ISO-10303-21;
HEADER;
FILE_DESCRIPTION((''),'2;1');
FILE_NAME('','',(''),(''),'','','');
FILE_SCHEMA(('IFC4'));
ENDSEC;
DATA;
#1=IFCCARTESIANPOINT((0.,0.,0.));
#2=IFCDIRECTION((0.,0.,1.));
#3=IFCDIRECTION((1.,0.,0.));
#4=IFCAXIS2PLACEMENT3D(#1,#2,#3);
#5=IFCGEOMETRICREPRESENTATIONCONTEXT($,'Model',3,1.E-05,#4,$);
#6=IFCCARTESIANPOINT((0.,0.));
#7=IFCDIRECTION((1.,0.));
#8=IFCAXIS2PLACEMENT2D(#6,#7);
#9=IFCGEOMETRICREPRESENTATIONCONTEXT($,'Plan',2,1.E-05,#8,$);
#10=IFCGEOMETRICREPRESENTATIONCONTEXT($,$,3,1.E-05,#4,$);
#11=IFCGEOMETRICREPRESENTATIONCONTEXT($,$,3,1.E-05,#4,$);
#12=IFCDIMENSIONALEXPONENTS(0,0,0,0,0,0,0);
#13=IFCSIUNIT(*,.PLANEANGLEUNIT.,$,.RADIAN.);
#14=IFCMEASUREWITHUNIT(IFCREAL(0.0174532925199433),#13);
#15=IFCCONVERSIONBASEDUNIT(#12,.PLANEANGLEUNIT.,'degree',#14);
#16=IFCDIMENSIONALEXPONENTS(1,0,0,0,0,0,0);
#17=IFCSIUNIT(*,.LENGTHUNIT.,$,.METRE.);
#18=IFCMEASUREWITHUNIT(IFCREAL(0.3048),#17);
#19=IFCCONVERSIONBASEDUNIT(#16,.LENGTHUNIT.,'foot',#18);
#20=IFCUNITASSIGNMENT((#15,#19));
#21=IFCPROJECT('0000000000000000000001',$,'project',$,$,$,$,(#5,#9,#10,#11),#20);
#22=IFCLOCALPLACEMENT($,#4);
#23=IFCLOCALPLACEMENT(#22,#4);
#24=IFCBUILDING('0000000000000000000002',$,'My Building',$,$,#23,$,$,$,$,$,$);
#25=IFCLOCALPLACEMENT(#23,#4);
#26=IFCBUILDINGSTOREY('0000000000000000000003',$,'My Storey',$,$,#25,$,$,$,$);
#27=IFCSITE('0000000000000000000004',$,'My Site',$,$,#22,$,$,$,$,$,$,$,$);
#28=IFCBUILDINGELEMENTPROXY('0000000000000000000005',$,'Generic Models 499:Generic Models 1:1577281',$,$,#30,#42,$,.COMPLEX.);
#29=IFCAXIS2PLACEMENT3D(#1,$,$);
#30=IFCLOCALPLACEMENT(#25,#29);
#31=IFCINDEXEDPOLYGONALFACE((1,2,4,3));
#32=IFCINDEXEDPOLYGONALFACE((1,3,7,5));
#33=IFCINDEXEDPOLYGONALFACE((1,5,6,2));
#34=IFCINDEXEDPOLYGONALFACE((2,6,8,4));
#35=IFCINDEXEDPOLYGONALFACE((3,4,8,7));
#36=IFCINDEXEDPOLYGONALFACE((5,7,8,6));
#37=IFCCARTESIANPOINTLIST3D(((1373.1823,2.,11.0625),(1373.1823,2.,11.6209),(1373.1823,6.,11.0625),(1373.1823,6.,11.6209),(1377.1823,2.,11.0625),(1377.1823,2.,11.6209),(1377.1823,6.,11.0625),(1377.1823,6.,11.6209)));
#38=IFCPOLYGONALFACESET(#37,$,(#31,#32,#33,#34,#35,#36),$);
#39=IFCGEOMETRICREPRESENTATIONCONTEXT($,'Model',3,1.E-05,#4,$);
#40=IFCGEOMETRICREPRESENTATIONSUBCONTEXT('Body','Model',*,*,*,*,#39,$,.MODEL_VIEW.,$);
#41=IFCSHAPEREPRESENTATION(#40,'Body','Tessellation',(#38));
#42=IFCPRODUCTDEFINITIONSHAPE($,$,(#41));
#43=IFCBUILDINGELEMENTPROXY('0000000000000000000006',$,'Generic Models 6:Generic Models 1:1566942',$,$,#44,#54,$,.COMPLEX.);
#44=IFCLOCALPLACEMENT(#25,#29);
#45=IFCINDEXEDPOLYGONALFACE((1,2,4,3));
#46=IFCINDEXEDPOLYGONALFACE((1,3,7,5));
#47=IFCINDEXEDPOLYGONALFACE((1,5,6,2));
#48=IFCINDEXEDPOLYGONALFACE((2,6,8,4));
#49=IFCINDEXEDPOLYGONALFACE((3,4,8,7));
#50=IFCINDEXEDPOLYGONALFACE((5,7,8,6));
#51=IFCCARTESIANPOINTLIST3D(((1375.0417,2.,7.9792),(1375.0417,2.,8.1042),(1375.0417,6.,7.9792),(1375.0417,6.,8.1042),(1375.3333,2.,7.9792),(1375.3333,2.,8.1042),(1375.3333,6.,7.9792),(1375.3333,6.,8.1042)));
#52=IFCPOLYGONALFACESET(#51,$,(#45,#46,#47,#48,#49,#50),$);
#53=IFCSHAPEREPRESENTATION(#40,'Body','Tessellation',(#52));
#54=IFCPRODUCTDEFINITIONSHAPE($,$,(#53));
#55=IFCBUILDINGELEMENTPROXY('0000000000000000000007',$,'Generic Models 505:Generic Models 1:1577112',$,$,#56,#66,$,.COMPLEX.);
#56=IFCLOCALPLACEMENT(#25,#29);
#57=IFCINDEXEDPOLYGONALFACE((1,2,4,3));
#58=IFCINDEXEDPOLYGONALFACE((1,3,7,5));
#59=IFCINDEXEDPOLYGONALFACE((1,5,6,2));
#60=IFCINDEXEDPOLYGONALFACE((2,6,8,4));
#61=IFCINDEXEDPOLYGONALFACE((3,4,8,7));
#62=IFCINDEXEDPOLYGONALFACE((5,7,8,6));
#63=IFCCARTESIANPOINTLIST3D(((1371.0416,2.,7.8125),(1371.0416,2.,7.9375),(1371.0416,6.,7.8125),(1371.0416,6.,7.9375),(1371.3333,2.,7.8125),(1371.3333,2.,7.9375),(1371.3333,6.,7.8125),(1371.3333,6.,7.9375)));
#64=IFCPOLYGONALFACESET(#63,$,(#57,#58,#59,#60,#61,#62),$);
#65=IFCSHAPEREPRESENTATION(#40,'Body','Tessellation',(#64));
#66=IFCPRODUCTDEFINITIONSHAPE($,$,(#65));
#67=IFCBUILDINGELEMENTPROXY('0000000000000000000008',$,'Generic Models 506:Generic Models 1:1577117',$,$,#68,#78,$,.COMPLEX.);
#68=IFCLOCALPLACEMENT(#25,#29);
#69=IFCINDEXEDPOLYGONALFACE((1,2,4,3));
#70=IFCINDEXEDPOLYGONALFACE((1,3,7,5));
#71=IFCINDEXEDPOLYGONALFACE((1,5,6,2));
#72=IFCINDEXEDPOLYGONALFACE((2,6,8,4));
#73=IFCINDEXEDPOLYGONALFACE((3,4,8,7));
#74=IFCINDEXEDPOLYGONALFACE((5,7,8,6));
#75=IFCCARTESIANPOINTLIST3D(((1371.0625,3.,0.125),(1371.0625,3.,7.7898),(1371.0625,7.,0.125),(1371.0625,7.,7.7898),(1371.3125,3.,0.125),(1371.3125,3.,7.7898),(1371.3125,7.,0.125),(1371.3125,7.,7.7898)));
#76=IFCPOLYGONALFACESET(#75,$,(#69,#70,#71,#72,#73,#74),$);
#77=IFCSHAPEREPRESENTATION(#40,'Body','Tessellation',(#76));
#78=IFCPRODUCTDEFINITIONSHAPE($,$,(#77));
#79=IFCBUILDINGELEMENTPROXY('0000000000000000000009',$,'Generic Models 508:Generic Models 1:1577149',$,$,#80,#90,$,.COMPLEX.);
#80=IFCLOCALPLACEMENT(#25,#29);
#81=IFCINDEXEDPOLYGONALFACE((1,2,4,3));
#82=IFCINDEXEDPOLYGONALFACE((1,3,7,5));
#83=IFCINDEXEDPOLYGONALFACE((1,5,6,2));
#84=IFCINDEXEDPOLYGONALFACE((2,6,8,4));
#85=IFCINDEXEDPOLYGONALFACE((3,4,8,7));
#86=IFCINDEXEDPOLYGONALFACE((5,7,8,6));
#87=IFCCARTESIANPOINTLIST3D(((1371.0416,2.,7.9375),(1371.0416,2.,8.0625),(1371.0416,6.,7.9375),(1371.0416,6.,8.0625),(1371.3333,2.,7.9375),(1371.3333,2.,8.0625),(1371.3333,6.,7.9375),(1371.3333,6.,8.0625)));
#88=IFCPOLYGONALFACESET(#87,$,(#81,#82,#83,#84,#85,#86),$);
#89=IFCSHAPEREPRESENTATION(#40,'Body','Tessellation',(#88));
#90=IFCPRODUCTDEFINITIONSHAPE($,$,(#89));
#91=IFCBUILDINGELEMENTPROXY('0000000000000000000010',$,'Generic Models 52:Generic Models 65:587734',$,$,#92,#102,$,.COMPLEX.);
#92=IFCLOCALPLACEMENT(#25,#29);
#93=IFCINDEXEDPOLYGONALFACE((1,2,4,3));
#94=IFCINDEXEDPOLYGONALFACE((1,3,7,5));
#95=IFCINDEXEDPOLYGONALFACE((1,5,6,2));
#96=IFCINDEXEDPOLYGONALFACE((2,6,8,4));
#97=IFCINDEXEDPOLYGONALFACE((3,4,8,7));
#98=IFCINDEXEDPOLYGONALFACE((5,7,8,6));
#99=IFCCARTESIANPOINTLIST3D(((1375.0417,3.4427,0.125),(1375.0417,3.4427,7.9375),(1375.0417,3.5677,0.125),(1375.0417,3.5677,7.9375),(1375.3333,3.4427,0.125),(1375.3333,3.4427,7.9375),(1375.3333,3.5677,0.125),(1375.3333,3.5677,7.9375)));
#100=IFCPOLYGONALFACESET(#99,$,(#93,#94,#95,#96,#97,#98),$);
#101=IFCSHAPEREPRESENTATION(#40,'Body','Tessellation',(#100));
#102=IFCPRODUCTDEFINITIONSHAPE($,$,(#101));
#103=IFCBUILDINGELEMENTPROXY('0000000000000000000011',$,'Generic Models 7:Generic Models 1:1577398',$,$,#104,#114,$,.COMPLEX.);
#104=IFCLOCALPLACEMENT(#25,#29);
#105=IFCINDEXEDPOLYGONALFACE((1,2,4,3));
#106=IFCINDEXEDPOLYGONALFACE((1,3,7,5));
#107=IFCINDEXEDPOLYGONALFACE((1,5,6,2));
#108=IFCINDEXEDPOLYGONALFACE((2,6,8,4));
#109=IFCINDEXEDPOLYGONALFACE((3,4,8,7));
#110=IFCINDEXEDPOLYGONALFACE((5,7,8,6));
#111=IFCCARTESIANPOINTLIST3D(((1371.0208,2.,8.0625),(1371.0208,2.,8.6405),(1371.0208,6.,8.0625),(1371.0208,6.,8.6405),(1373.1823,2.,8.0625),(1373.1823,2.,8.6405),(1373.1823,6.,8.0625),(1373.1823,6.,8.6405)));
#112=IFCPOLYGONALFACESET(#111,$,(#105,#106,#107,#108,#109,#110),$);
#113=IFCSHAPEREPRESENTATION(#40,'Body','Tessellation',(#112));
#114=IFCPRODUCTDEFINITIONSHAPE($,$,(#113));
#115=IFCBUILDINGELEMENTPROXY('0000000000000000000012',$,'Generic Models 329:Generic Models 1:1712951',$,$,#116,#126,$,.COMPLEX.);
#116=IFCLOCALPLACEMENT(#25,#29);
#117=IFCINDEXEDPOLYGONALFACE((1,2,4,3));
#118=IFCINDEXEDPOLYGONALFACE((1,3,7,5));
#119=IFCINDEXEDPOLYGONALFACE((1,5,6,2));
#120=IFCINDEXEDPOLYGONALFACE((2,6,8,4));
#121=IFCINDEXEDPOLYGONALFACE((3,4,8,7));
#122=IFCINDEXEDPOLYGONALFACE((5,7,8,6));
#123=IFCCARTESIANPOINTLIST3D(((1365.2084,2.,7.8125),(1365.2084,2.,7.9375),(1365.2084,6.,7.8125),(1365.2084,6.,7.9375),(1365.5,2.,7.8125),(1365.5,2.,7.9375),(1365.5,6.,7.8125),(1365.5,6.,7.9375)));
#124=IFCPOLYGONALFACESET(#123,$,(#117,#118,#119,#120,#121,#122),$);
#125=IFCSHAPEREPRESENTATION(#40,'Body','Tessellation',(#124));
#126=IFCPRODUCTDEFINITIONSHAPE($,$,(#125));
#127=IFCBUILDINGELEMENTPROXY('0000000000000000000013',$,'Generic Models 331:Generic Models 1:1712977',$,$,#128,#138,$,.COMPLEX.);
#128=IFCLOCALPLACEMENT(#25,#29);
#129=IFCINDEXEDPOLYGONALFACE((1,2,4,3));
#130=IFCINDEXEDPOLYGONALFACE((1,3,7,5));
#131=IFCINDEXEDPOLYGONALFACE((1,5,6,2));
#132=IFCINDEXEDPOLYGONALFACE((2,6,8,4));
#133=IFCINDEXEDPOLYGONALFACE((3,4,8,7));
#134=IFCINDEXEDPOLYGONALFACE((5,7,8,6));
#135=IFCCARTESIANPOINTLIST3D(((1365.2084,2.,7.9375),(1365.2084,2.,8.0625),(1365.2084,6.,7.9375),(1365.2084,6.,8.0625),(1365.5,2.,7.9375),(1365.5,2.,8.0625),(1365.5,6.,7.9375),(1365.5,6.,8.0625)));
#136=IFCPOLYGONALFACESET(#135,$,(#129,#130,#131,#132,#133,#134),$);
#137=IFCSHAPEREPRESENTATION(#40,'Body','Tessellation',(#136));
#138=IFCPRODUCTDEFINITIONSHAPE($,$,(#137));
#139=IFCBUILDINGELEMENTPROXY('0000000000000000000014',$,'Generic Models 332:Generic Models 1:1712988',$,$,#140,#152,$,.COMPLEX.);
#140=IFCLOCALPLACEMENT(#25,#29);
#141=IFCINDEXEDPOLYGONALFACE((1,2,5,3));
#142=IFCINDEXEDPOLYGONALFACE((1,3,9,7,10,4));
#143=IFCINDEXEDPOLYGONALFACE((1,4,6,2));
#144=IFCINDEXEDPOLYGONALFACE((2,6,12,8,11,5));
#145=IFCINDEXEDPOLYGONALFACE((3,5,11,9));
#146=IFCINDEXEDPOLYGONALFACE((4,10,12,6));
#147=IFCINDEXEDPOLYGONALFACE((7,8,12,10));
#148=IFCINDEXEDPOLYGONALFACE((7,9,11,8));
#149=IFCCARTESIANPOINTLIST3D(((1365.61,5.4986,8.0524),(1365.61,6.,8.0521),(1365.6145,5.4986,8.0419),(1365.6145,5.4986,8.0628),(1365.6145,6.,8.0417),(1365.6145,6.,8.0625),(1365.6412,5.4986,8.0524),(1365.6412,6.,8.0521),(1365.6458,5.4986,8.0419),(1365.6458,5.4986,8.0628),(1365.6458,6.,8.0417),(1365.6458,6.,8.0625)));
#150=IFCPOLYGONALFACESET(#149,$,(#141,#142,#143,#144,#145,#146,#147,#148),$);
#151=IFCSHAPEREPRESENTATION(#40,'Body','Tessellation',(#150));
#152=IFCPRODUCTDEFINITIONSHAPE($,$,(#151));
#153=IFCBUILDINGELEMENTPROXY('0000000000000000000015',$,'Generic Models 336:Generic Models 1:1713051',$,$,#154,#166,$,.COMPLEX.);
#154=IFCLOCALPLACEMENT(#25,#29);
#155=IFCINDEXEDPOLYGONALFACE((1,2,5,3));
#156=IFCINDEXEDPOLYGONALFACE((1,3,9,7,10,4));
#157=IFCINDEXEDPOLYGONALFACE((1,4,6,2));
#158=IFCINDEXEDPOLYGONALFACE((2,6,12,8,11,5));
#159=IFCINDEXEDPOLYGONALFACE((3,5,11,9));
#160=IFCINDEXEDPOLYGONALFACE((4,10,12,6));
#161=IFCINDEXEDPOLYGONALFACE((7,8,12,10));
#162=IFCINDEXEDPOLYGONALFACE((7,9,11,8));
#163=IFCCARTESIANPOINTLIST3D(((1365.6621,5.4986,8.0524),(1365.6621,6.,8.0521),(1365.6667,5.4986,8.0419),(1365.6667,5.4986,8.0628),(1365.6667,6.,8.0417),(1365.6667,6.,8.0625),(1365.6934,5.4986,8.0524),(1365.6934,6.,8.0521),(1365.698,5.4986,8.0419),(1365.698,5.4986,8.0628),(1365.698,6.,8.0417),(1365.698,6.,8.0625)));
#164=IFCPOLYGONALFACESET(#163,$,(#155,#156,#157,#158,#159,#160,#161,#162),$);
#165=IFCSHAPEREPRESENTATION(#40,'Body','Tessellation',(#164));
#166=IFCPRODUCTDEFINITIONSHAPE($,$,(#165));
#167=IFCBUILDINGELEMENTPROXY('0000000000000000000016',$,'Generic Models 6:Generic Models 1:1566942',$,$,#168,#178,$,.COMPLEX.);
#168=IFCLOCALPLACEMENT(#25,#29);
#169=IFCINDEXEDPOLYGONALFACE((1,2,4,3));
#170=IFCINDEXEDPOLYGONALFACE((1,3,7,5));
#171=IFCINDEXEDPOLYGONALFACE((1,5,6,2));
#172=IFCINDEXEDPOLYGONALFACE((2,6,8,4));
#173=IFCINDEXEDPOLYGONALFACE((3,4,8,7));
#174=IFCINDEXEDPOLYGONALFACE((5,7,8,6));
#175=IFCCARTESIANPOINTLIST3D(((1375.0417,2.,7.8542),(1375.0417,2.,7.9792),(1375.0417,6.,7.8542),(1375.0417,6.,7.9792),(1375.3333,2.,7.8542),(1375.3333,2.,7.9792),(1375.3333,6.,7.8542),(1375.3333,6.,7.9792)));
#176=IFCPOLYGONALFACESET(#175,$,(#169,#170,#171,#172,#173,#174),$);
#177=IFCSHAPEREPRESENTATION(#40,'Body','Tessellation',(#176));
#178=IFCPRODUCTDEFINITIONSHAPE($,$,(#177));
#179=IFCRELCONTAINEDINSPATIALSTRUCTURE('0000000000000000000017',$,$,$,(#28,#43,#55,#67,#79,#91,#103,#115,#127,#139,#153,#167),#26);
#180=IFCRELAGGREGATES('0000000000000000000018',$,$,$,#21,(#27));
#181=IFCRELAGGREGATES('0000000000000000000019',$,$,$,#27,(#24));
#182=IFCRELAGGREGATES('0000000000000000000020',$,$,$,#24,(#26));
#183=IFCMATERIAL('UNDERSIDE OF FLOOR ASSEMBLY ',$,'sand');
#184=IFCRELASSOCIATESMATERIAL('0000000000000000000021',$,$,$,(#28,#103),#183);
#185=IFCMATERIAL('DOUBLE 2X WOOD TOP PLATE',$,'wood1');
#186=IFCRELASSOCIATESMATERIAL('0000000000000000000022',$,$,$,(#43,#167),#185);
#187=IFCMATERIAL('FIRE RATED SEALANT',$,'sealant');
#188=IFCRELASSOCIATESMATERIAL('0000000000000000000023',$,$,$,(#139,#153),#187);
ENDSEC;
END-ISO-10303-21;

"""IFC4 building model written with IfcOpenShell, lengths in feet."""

from ifc_helpers import new_model, entity, si_unit, converted_unit, frame, origin_with_axes, origin_2d_with_axis, place, context, subcontext, project, spatial, polyline, line, indexed_curve, outline, extrude, material, element, save


model = new_model("IFC4")

# Units and contexts
model_context_1 = context("Model", 3, precision=1e-05, world=origin_with_axes())
plan_context = context("Plan", 2, precision=1e-05, world=origin_2d_with_axis())
model_context_2 = context("Model", 3, precision=1e-05, world=origin_with_axes())
context_of_model_1 = context(None, 3, precision=1e-05, world=origin_with_axes())
context_of_model_2 = context(None, 3, precision=1e-05, world=origin_with_axes())
body_context = subcontext(model_context_2, "Body", "Model", "MODEL_VIEW")
ifc_project = project(units=[converted_unit("PLANEANGLEUNIT", "degree", entity("IfcReal", 0.0174532925199433), si_unit("PLANEANGLEUNIT", "RADIAN"), dimensions=[0, 0, 0, 0, 0, 0, 0]), converted_unit("LENGTHUNIT", "foot", entity("IfcReal", 0.3048), si_unit("LENGTHUNIT", "METRE"), dimensions=[1, 0, 0, 0, 0, 0, 0])], contexts=[model_context_1, plan_context, context_of_model_1, context_of_model_2])

# Site, building, storey
site_placement = place(None, origin_with_axes())
site = spatial("IfcSite", under=ifc_project, at=site_placement, Name="My Site")
building_placement = place(site_placement, origin_with_axes())
building = spatial("IfcBuilding", under=site, at=building_placement, Name="My Building")
storey_placement = place(building_placement, origin_with_axes())
storey = spatial("IfcBuildingStorey", under=building, at=storey_placement, Name="My Storey")

# Building element proxies
ifc_material_1 = material(Name="UNDERSIDE OF FLOOR ASSEMBLY ", Category="sand")
proxy_1_placement = place(storey_placement, frame((1373.1823, 6.0, 11.0625), z_axis=(0.0, -1.0, 0.0), x_axis=(0.0, 0.0, -1.0)))
element("IfcBuildingElementProxy", 1, at=proxy_1_placement, inside=storey, material=ifc_material_1, Name="Generic Models 499:Generic Models 1:1577281", PredefinedType="COMPLEX", context=body_context, shape_type="SweptSolid", body=[
    extrude(outline(indexed_curve([(-0.2792, -2.0), (0.2792, -2.0), (0.2792, 2.0), (-0.2792, 2.0)], segments=[line(3, 2), line(2, 1), line(1, 4), line(4, 3)], self_intersect=False)), frame((-0.2792, 2.0, 0.0), z_axis=(0.0, 0.0, -1.0), x_axis=(1.0, 0.0, 0.0)), (0.0, 0.0, -1.0), 4.0),
])
ifc_material_2 = material(Name="DOUBLE 2X WOOD TOP PLATE", Category="wood1")
proxy_2_placement = place(storey_placement, frame((1375.0417, 6.0, 7.9792), z_axis=(0.0, -1.0, 0.0), x_axis=(0.0, 0.0, -1.0)))
element("IfcBuildingElementProxy", 2, at=proxy_2_placement, inside=storey, material=ifc_material_2, Name="Generic Models 6:Generic Models 1:1566942", PredefinedType="COMPLEX", context=body_context, shape_type="SweptSolid", body=[
    extrude(outline(indexed_curve([(-0.0625, -0.1458), (0.0625, -0.1458), (0.0625, 0.1458), (-0.0625, 0.1458)], segments=[line(3, 2), line(2, 1), line(1, 4), line(4, 3)], self_intersect=False)), frame((-0.0625, 0.1458, 0.0), z_axis=(0.0, 0.0, -1.0), x_axis=(-1.0, 0.0, 0.0)), (0.0, 0.0, -1.0), 4.0),
])
proxy_3_placement = place(storey_placement, frame((1371.0416, 6.0, 7.8125), z_axis=(0.0, -1.0, 0.0), x_axis=(0.0, 0.0, -1.0)))
element("IfcBuildingElementProxy", 3, at=proxy_3_placement, inside=storey, Name="Generic Models 505:Generic Models 1:1577112", PredefinedType="COMPLEX", context=body_context, shape_type="SweptSolid", body=[
    extrude(outline(polyline([(-0.0625, -0.1458), (0.0625, -0.1458), (0.0625, 0.1458), (-0.0625, 0.1458), (-0.0625, -0.1458)])), frame((-0.0625, 0.1458, 0.0), z_axis=(0.0, 0.0, -1.0), x_axis=(1.0, 0.0, 0.0)), (0.0, 0.0, -1.0), 4.0),
])
proxy_4_placement = place(storey_placement, frame((1371.0625, 3.0, 0.125), z_axis=(0.0, 1.0, 0.0), x_axis=(0.0, 0.0, -1.0)))
element("IfcBuildingElementProxy", 4, at=proxy_4_placement, inside=storey, Name="Generic Models 506:Generic Models 1:1577117", PredefinedType="COMPLEX", context=body_context, shape_type="SweptSolid", body=[
    extrude(outline(polyline([(-3.8324, -0.125), (3.8324, -0.125), (3.8324, 0.125), (-3.8324, 0.125), (-3.8324, -0.125)])), frame((-3.8324, -0.125, 0.0), z_axis=(0.0, 0.0, -1.0), x_axis=(-1.0, 0.0, 0.0)), (0.0, 0.0, -1.0), 4.0),
])
proxy_5_placement = place(storey_placement, frame((1371.0416, 6.0, 7.9375), z_axis=(0.0, -1.0, 0.0), x_axis=(0.0, 0.0, -1.0)))
element("IfcBuildingElementProxy", 5, at=proxy_5_placement, inside=storey, Name="Generic Models 508:Generic Models 1:1577149", PredefinedType="COMPLEX", context=body_context, shape_type="SweptSolid", body=[
    extrude(outline(polyline([(-0.0625, -0.1458), (0.0625, -0.1458), (0.0625, 0.1458), (-0.0625, 0.1458), (-0.0625, -0.1458)])), frame((-0.0625, 0.1458, 0.0), z_axis=(0.0, 0.0, -1.0), x_axis=(1.0, 0.0, 0.0)), (0.0, 0.0, -1.0), 4.0),
])
proxy_6_placement = place(storey_placement, frame((1375.0417, 3.4427, 0.125), z_axis=(1.0, 0.0, 0.0), x_axis=(0.0, 0.0, -1.0)))
element("IfcBuildingElementProxy", 6, at=proxy_6_placement, inside=storey, Name="Generic Models 52:Generic Models 65:587734", PredefinedType="COMPLEX", context=body_context, shape_type="SweptSolid", body=[
    extrude(outline(polyline([(-3.9062, -0.0625), (3.9062, -0.0625), (3.9062, 0.0625), (-3.9062, 0.0625), (-3.9062, -0.0625)])), frame((-3.9062, 0.0625, 0.0), z_axis=(0.0, 0.0, -1.0), x_axis=(-1.0, 0.0, 0.0)), (0.0, 0.0, -1.0), 0.2917),
])
proxy_7_placement = place(storey_placement, frame((1371.0208, 6.0, 8.0625), z_axis=(0.0, -1.0, 0.0), x_axis=(0.0, 0.0, -1.0)))
element("IfcBuildingElementProxy", 7, at=proxy_7_placement, inside=storey, material=ifc_material_1, Name="Generic Models 7:Generic Models 1:1577398", PredefinedType="COMPLEX", context=body_context, shape_type="SweptSolid", body=[
    extrude(outline(polyline([(-0.289, -1.0807), (0.289, -1.0807), (0.289, 1.0807), (-0.289, 1.0807), (-0.289, -1.0807)])), frame((-0.289, 1.0807, 0.0), z_axis=(0.0, 0.0, -1.0), x_axis=(-1.0, 0.0, 0.0)), (0.0, 0.0, -1.0), 4.0),
])
for number, where, z_axis, x_axis, name in (
    (8, (1365.2084, 6.0, 7.8125), (0.0, -1.0, 0.0), (0.0, 0.0, 1.0), "Generic Models 329:Generic Models 1:1712951"),
    (9, (1365.2084, 6.0, 7.9375), (0.0, -1.0, 0.0), (0.0, 0.0, 1.0), "Generic Models 331:Generic Models 1:1712977"),
):
    element("IfcBuildingElementProxy", number, at=place(storey_placement, frame(where, z_axis=z_axis, x_axis=x_axis)), inside=storey, Name=name, PredefinedType="COMPLEX", context=body_context, shape_type="SweptSolid", body=[
        extrude(outline(polyline([(-0.1458, -0.0625), (0.1458, -0.0625), (0.1458, 0.0625), (-0.1458, 0.0625), (-0.1458, -0.0625)])), frame((0.0625, -0.1458, 0.0), z_axis=(0.0, 0.0, -1.0), x_axis=(0.0, 1.0, 0.0)), (0.0, 0.0, -1.0), 4.0),
    ])
ifc_material_3 = material(Name="FIRE RATED SEALANT", Category="sealant")
for number, where, z_axis, x_axis, name in (
    (10, (1365.6101, 6.0, 8.0417), (0.0, -1.0, 0.0), (0.0, 0.0, 1.0), "Generic Models 332:Generic Models 1:1712988"),
    (11, (1365.6622, 6.0, 8.0417), (0.0, -1.0, 0.0), (0.0, 0.0, 1.0), "Generic Models 336:Generic Models 1:1713051"),
):
    element("IfcBuildingElementProxy", number, at=place(storey_placement, frame(where, z_axis=z_axis, x_axis=x_axis)), inside=storey, material=ifc_material_3, Name=name, PredefinedType="COMPLEX", context=body_context, shape_type="SweptSolid", body=[
        extrude(outline(polyline([(0.0201, 0.0), (0.0107, 0.0065), (0.0093, 0.0178), (-0.0175, 0.0016), (-0.016, -0.0097), (-0.0066, -0.0162), (0.0201, 0.0)])), frame((0.0104, -0.0186, 0.0), z_axis=(0.0, 0.0, -1.0), x_axis=(0.51911, -0.854707, 0.0)), (0.000294, -0.000474, -1.0), 0.5014),
    ])
proxy_8_placement = place(storey_placement, frame((1375.0417, 6.0, 7.8542), z_axis=(0.0, -1.0, 0.0), x_axis=(0.0, 0.0, -1.0)))
element("IfcBuildingElementProxy", 12, at=proxy_8_placement, inside=storey, material=ifc_material_2, Name="Generic Models 6:Generic Models 1:1566942", PredefinedType="COMPLEX", context=body_context, shape_type="SweptSolid", body=[
    extrude(outline(indexed_curve([(-0.0625, -0.1458), (0.0625, -0.1458), (0.0625, 0.1458), (-0.0625, 0.1458)], segments=[line(3, 2), line(2, 1), line(1, 4), line(4, 3)], self_intersect=False)), frame((-0.0625, 0.1458, 0.0), z_axis=(0.0, 0.0, -1.0), x_axis=(-1.0, 0.0, 0.0)), (0.0, 0.0, -1.0), 4.0),
])

save(model, "model.ifc")
